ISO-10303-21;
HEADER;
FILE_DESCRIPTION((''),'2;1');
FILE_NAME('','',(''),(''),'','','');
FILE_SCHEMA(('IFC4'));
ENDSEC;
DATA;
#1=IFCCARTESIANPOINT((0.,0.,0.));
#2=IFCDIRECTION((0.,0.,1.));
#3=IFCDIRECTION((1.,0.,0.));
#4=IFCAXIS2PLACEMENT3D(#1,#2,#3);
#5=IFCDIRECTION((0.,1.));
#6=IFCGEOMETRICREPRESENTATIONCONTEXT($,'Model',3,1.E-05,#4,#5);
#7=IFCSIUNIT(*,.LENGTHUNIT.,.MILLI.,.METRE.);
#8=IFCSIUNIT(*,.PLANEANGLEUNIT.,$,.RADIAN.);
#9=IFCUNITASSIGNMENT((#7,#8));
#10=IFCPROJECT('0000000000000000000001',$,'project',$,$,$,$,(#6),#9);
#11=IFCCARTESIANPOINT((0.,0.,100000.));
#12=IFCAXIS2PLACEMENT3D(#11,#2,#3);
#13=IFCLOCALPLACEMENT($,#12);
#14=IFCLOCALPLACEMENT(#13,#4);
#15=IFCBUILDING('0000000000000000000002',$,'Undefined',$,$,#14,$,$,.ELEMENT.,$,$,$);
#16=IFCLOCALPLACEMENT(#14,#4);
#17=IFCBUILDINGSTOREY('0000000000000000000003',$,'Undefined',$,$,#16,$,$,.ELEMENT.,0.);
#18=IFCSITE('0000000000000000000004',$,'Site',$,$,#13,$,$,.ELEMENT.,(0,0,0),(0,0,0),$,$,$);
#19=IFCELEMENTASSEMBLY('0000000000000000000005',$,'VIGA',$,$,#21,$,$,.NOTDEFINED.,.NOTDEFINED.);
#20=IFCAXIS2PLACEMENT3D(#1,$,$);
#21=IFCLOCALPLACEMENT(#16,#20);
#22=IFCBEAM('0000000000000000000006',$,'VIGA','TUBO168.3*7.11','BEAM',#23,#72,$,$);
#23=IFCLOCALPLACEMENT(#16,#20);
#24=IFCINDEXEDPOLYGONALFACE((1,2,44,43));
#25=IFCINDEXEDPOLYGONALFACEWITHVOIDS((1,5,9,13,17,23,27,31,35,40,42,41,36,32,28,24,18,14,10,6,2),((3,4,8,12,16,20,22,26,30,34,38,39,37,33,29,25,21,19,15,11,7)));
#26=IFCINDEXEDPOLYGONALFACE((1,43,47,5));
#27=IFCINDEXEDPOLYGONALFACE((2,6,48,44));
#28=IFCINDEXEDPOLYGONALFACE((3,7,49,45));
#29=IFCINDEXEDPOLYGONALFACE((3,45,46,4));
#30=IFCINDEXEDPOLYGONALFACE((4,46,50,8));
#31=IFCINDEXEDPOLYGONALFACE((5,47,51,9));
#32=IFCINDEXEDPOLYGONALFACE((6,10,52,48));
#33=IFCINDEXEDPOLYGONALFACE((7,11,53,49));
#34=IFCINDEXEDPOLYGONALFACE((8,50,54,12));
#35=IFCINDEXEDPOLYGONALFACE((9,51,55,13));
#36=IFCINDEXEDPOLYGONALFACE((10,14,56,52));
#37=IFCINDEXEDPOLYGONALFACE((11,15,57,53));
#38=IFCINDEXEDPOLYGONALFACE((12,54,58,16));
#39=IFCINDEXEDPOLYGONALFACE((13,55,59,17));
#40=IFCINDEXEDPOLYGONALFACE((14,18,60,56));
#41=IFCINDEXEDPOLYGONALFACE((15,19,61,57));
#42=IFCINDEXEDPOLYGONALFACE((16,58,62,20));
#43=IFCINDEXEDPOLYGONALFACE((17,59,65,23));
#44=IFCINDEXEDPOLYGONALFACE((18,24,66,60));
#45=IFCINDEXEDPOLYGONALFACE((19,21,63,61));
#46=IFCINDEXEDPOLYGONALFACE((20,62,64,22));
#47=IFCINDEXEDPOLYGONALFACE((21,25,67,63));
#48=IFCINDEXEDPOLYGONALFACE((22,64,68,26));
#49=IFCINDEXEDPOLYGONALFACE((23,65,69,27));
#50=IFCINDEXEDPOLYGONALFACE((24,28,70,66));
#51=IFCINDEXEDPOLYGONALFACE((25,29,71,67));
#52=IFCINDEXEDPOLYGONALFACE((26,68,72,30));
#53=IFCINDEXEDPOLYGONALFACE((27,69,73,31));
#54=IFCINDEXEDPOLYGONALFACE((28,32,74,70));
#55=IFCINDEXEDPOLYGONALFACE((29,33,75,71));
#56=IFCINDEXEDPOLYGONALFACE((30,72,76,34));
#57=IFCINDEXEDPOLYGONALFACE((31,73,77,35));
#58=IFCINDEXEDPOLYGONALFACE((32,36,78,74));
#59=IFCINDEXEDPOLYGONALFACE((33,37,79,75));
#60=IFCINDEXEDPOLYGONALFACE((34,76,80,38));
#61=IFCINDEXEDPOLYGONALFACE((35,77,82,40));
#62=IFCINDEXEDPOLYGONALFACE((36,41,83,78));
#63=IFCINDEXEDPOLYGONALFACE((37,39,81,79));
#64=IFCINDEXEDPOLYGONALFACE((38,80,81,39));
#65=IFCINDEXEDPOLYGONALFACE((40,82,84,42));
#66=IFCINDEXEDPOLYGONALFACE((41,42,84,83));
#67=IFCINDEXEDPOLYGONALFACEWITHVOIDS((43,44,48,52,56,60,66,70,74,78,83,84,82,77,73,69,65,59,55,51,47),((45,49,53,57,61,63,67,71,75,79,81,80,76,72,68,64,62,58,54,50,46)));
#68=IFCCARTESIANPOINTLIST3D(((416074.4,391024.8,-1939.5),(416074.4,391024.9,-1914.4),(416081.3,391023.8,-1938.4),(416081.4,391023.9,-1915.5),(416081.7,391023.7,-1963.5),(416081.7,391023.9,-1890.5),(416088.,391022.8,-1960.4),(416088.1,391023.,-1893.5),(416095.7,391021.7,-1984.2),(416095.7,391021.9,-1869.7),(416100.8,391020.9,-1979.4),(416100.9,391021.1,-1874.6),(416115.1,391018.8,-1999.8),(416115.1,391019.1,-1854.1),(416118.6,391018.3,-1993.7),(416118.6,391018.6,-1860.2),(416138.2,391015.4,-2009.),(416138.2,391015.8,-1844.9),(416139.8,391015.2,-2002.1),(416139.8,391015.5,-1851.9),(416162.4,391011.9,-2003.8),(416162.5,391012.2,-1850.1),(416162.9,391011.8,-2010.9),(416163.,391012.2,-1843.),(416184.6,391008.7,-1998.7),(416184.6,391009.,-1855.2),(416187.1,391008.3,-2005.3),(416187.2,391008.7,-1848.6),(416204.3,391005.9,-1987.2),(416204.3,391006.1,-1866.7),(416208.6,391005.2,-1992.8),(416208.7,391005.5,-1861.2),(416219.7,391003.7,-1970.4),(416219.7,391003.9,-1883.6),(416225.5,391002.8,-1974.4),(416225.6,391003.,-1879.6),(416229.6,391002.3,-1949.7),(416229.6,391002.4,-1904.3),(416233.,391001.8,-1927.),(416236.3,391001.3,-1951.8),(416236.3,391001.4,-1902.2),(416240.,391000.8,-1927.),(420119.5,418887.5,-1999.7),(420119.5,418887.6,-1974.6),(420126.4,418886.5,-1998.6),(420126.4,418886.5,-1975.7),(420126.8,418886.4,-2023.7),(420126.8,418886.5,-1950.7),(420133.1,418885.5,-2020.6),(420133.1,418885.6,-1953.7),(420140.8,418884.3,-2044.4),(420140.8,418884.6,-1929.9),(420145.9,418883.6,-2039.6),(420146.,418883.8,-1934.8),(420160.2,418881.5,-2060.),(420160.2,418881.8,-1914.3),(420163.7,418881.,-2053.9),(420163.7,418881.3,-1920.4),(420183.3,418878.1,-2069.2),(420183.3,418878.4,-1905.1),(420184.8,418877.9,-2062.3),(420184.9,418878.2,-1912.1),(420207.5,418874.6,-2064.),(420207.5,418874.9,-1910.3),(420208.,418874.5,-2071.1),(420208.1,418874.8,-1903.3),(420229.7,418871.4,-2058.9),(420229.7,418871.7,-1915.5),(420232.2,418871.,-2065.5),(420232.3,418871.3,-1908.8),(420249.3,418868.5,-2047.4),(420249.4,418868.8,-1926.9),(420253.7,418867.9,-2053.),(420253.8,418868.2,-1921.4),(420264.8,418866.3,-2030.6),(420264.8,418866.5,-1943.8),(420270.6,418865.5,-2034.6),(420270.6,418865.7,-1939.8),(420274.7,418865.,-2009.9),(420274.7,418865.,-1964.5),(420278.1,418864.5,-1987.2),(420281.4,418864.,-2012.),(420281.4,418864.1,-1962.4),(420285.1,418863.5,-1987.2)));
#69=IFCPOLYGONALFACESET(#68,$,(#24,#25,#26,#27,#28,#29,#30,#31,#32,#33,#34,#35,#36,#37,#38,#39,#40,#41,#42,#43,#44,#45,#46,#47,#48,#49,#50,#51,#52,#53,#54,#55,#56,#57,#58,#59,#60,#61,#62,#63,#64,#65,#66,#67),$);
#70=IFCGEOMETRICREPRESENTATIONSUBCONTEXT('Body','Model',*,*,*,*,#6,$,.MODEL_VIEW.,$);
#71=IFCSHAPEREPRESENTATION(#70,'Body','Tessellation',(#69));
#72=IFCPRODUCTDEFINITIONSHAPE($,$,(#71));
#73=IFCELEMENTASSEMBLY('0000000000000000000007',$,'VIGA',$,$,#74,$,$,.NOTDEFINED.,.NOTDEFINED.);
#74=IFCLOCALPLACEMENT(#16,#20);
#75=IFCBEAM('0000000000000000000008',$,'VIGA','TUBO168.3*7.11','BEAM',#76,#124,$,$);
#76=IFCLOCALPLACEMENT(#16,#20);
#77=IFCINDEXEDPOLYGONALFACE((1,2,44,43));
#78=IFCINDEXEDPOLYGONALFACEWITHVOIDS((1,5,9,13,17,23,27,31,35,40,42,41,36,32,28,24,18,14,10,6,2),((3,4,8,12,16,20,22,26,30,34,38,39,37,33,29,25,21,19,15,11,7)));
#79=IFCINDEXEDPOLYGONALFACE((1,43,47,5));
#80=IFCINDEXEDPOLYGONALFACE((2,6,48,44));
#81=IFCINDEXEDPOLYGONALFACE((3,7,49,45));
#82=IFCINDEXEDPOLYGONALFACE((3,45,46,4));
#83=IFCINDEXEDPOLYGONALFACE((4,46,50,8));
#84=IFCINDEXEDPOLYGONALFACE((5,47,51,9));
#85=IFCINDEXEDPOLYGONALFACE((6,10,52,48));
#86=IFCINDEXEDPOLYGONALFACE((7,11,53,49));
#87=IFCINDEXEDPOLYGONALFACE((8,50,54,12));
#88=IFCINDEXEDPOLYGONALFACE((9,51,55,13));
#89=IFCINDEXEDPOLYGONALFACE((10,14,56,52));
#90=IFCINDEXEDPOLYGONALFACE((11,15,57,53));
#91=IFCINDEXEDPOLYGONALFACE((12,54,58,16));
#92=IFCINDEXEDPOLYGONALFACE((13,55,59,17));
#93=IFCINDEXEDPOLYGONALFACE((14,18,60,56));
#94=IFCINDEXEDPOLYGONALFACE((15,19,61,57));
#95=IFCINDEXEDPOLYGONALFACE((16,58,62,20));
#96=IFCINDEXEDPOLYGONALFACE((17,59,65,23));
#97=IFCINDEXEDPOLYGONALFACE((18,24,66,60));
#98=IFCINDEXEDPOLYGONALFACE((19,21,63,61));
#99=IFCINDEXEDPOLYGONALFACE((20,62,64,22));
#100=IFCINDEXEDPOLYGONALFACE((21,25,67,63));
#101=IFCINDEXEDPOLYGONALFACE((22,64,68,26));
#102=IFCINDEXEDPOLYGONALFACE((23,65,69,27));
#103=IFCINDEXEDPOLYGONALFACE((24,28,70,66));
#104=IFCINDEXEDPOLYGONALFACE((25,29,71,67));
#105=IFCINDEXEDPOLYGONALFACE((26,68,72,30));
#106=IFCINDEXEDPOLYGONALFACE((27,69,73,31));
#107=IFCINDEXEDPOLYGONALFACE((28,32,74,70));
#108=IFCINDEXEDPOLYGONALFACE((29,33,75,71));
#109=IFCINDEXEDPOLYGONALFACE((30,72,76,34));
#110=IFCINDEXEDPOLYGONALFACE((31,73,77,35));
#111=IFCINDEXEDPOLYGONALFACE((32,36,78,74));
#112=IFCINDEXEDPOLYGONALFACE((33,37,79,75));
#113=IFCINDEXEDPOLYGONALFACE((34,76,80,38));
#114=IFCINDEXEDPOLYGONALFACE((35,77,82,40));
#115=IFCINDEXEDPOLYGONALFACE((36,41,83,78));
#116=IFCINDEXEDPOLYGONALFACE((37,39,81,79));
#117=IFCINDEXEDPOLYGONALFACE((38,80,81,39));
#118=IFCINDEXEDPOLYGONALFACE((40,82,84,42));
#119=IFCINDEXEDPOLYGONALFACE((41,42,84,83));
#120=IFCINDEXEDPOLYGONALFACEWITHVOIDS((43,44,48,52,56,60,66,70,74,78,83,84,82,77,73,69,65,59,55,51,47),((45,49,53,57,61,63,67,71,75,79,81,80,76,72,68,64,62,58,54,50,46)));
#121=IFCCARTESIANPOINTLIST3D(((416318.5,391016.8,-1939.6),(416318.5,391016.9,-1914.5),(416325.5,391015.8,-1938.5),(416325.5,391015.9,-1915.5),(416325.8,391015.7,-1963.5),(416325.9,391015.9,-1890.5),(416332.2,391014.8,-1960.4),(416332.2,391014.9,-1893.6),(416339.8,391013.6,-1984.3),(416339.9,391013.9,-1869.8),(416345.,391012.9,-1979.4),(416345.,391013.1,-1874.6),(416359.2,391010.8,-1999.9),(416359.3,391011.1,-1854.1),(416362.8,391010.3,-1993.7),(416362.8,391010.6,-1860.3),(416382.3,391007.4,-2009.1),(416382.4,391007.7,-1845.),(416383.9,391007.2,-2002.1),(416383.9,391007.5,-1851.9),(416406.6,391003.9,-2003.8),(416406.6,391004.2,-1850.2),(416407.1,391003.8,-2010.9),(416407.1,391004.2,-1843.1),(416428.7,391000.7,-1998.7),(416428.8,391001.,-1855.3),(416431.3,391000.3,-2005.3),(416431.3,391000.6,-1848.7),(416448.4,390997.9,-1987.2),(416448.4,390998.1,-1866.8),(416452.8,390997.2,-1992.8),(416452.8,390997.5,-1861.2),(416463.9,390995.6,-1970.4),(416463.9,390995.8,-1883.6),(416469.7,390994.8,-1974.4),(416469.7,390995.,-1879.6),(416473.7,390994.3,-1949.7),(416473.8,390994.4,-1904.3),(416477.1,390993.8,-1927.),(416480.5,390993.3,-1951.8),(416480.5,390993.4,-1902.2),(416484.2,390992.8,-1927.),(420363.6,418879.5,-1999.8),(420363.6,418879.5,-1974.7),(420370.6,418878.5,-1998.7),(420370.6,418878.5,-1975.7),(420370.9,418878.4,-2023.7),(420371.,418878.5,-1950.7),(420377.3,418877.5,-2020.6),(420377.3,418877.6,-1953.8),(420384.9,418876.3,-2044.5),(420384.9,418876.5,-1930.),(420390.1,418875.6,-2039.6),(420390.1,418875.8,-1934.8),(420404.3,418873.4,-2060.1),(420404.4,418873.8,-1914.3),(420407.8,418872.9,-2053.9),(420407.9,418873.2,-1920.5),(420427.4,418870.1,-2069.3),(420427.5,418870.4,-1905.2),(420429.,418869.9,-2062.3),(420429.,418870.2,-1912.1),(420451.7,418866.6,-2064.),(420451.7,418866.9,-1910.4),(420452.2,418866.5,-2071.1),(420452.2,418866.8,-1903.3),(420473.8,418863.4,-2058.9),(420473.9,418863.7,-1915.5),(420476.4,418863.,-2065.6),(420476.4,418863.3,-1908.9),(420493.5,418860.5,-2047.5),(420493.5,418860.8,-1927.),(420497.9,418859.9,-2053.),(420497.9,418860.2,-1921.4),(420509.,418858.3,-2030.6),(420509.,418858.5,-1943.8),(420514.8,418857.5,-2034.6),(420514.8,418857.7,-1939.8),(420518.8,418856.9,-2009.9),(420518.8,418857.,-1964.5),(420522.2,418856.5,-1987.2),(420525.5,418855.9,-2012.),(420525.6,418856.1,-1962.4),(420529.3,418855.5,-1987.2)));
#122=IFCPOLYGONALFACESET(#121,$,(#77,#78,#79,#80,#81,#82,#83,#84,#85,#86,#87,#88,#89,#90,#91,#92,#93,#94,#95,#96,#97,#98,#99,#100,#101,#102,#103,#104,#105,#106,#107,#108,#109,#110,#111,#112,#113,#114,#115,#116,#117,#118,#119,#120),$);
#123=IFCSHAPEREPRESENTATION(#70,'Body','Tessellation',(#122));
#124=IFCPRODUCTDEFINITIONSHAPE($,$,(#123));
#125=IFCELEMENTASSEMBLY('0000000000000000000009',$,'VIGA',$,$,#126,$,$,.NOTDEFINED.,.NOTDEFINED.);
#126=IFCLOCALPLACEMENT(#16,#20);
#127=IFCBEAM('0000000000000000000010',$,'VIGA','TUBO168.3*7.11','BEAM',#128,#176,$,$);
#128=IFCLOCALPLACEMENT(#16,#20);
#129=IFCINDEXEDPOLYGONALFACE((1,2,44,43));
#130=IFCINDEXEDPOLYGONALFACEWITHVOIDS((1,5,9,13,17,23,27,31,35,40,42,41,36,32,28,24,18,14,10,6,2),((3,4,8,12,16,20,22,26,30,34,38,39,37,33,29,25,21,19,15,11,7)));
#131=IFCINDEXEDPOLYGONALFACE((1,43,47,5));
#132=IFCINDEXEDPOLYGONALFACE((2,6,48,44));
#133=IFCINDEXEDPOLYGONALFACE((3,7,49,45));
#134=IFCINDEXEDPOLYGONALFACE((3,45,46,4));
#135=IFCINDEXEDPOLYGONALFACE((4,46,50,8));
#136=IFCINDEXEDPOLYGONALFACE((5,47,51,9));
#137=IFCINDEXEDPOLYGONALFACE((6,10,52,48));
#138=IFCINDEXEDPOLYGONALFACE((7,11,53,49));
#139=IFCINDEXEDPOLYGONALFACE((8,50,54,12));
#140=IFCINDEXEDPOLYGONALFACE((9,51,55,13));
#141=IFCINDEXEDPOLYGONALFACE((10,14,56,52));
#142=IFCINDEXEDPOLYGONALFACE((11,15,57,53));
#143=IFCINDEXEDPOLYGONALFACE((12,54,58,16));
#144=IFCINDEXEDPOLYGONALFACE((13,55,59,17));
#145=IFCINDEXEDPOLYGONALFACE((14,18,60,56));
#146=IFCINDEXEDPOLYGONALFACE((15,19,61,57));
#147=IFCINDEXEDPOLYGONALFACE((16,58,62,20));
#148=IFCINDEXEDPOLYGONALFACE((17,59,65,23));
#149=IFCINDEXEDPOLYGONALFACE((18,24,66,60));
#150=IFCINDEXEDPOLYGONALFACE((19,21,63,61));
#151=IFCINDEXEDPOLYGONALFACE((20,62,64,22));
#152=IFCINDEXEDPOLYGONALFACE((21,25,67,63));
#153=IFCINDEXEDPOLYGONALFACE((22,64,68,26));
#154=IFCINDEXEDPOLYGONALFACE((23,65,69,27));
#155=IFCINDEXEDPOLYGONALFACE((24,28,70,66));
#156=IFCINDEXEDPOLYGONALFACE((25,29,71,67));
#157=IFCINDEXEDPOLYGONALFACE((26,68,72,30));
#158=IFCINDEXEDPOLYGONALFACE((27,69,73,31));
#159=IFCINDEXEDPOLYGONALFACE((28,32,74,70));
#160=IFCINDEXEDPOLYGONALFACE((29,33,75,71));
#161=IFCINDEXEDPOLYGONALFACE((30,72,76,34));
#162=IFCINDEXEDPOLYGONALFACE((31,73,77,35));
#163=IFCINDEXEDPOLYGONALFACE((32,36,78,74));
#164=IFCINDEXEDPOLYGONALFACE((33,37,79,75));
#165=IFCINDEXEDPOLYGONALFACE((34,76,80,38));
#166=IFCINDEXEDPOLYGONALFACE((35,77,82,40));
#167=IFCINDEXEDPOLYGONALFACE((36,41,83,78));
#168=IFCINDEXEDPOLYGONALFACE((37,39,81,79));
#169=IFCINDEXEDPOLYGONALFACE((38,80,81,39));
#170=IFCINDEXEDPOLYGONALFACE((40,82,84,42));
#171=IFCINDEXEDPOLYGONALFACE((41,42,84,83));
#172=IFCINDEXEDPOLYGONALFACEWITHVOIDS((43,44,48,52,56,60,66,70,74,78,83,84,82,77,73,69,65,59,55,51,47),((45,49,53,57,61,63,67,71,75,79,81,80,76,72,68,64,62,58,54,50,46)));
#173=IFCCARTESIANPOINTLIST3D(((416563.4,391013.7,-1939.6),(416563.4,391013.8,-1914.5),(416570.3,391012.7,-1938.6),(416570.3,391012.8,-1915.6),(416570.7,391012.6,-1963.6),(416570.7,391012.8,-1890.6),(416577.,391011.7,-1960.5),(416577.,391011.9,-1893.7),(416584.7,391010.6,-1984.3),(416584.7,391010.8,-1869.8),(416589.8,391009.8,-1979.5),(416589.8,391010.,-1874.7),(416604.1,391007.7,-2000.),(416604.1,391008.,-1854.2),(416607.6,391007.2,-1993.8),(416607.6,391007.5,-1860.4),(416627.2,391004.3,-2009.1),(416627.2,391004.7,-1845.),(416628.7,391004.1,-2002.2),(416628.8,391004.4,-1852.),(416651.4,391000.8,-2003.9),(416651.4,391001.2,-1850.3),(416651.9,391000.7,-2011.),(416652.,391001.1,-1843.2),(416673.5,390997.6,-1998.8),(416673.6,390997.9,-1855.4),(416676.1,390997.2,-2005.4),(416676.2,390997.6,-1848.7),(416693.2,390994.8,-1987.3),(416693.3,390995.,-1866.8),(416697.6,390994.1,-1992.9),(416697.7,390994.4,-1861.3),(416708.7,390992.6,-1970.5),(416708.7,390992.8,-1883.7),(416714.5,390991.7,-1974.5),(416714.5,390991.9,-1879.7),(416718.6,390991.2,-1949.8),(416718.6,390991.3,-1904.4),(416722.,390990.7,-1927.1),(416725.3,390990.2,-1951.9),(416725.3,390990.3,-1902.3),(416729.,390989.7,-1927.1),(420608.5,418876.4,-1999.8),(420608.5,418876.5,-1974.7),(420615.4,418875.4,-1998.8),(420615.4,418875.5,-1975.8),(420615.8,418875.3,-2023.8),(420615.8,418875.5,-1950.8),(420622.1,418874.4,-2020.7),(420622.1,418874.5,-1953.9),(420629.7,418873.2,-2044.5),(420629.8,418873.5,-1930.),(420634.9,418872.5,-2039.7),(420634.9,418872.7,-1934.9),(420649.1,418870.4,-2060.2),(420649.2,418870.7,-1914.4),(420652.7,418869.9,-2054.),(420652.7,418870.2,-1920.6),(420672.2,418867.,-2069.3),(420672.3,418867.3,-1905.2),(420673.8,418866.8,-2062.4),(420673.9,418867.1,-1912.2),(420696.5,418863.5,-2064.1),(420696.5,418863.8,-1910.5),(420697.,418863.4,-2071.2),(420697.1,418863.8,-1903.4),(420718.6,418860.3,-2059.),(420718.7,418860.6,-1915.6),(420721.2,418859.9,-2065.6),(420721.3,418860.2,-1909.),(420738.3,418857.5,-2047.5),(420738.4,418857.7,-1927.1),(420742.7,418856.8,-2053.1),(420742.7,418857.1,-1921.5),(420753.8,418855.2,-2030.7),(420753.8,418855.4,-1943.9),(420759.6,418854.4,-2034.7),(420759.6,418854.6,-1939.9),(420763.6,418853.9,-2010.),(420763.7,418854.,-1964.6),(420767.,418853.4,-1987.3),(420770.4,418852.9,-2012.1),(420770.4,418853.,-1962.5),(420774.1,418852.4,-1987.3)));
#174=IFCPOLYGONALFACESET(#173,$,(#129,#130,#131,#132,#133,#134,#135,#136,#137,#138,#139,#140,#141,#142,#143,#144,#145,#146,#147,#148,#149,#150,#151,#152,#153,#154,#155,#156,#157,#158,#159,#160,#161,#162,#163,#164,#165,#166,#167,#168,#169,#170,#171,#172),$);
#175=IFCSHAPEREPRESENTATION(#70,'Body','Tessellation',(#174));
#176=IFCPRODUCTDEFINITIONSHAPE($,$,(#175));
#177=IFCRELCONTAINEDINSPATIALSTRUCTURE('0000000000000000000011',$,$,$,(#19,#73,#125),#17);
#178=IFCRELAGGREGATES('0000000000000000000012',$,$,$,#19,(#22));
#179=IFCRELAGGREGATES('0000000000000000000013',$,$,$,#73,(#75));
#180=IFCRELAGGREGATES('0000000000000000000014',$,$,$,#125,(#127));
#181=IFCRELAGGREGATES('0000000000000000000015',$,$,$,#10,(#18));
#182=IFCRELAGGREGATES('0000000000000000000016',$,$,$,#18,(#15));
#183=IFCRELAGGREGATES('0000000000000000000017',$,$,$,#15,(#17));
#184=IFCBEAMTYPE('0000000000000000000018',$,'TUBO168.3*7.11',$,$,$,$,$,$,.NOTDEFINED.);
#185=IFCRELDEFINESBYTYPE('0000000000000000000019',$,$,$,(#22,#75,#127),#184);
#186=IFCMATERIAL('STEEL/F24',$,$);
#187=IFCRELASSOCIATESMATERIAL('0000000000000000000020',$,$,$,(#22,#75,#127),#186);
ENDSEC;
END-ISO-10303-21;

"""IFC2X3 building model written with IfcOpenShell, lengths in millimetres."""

from ifc_helpers import new_model, si_unit, direction, frame, origin_with_axes, origin_2d_with_axis, place, context, subcontext, project, spatial, hollow_circle, extrude, material, type_object, element, aggregate, save


model = new_model("IFC2X3")

# Units and contexts
model_context = context("Model", 3, precision=1e-05, world=origin_with_axes(), true_north=direction((0.0, 1.0)))
body_context = subcontext(model_context, "Body", "Model", "MODEL_VIEW")
ifc_project = project(units=[si_unit("LENGTHUNIT", "METRE", prefix="MILLI"), si_unit("PLANEANGLEUNIT", "RADIAN")], contexts=[model_context])

# Site, building, storey
site_placement = place(None, frame((0.0, 0.0, 100000.0), z_axis=(0.0, 0.0, 1.0), x_axis=(1.0, 0.0, 0.0)))
site = spatial("IfcSite", under=ifc_project, at=site_placement, Name="Site", CompositionType="ELEMENT", RefLatitude=(0, 0, 0), RefLongitude=(0, 0, 0))
building_placement = place(site_placement, origin_with_axes())
building = spatial("IfcBuilding", under=site, at=building_placement, Name="Undefined", CompositionType="ELEMENT")
storey_placement = place(building_placement, origin_with_axes())
storey = spatial("IfcBuildingStorey", under=building, at=storey_placement, Name="Undefined", CompositionType="ELEMENT", Elevation=0.0)

# Element assemblies, beams
assembly_1_placement = place(storey_placement, origin_with_axes())
assembly_1 = element("IfcElementAssembly", 1, at=assembly_1_placement, inside=storey, Name="VIGA", AssemblyPlace="NOTDEFINED", PredefinedType="NOTDEFINED")
ifc_material_1 = material(Name="STEEL/F24")
beam_type_1 = type_object("IfcBeamType", Name="TUBO168.3*7.11", PredefinedType="NOTDEFINED")
beam_1_placement = place(assembly_1_placement, frame((416156.7, 391012.9, -1927.0), z_axis=(0.000307, 0.002116, 0.999998), x_axis=(0.143673, 0.989623, -0.002138)))
beam_1 = element("IfcBeam", 2, at=beam_1_placement, type_object=beam_type_1, material=ifc_material_1, Name="VIGA", Description="TUBO168.3*7.11", ObjectType="BEAM", context=body_context, shape_type="SweptSolid", body=[
    extrude(hollow_circle(Radius=84.2, WallThickness=7.1, at=origin_2d_with_axis()), frame((28154.8, 0.0, 0.0), z_axis=(-1.0, 0.0, 0.0), x_axis=(0.0, -1.0, 0.0)), (0.0, 0.0, 1.0), 28154.8),
])
aggregate(assembly_1, [beam_1])
assembly_2_placement = place(storey_placement, origin_with_axes())
assembly_2 = element("IfcElementAssembly", 3, at=assembly_2_placement, inside=storey, Name="VIGA", AssemblyPlace="NOTDEFINED", PredefinedType="NOTDEFINED")
beam_2_placement = place(assembly_2_placement, frame((416400.9, 391004.9, -1927.0), z_axis=(0.000307, 0.002116, 0.999998), x_axis=(0.143673, 0.989623, -0.002138)))
beam_2 = element("IfcBeam", 4, at=beam_2_placement, type_object=beam_type_1, material=ifc_material_1, Name="VIGA", Description="TUBO168.3*7.11", ObjectType="BEAM", context=body_context, shape_type="SweptSolid", body=[
    extrude(hollow_circle(Radius=84.2, WallThickness=7.1, at=origin_2d_with_axis()), frame((28154.8, 0.0, 0.0), z_axis=(-1.0, 0.0, 0.0), x_axis=(0.0, -1.0, 0.0)), (0.0, 0.0, 1.0), 28154.8),
])
aggregate(assembly_2, [beam_2])
assembly_3_placement = place(storey_placement, origin_with_axes())
assembly_3 = element("IfcElementAssembly", 5, at=assembly_3_placement, inside=storey, Name="VIGA", AssemblyPlace="NOTDEFINED", PredefinedType="NOTDEFINED")
beam_3_placement = place(assembly_3_placement, frame((416645.7, 391001.8, -1927.1), z_axis=(0.000307, 0.002116, 0.999998), x_axis=(0.143673, 0.989623, -0.002138)))
beam_3 = element("IfcBeam", 6, at=beam_3_placement, type_object=beam_type_1, material=ifc_material_1, Name="VIGA", Description="TUBO168.3*7.11", ObjectType="BEAM", context=body_context, shape_type="SweptSolid", body=[
    extrude(hollow_circle(Radius=84.2, WallThickness=7.1, at=origin_2d_with_axis()), frame((28154.8, 0.0, 0.0), z_axis=(-1.0, 0.0, 0.0), x_axis=(0.0, -1.0, 0.0)), (0.0, 0.0, 1.0), 28154.8),
])
aggregate(assembly_3, [beam_3])

save(model, "model.ifc")
